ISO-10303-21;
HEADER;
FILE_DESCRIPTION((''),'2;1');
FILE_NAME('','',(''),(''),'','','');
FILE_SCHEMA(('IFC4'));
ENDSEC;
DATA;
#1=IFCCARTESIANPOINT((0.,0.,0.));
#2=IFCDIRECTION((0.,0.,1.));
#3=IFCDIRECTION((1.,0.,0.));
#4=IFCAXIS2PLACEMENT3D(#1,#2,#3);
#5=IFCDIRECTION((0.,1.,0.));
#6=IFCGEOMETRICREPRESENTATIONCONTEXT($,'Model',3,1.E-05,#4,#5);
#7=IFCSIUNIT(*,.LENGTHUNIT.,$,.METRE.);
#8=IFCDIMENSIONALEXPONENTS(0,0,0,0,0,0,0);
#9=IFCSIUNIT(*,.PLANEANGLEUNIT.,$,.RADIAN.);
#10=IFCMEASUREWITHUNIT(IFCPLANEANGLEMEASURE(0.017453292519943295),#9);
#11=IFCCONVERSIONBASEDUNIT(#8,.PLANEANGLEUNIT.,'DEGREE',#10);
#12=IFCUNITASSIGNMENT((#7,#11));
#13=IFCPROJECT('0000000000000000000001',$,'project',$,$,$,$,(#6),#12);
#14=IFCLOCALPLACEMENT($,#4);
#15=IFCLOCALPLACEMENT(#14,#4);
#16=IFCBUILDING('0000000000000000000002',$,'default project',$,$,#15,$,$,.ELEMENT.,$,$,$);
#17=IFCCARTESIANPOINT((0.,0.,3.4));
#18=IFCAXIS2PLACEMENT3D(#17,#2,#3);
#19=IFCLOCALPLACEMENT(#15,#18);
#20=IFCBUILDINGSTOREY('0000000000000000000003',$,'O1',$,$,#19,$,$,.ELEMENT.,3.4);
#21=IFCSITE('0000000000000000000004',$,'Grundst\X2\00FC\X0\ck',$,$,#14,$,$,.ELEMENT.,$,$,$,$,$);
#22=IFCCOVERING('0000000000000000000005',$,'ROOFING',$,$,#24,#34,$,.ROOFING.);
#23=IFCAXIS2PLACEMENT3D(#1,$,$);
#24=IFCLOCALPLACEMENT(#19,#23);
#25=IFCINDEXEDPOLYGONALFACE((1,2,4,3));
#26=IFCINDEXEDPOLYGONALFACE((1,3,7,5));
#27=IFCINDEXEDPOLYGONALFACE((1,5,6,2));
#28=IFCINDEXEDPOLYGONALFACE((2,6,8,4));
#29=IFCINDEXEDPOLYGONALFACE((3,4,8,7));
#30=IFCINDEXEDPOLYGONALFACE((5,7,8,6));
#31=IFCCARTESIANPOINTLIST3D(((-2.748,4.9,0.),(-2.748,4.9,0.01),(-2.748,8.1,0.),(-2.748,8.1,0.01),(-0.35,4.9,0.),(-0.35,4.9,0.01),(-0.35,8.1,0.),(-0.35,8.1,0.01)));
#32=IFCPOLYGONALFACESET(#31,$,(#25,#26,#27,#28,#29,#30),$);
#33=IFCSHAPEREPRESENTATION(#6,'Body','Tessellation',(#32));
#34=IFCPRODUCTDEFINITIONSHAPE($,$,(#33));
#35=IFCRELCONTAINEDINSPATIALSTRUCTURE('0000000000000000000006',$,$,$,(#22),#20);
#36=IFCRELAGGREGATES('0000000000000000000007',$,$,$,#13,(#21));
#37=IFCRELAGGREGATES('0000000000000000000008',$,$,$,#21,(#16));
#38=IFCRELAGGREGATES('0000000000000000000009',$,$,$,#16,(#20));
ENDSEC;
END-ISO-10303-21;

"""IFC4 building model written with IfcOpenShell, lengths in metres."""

from ifc_helpers import new_model, entity, si_unit, converted_unit, direction, frame, origin_with_axes, place, context, project, spatial, polyline, outline, extrude, element, save


model = new_model("IFC4")

# Units and contexts
model_context = context("Model", 3, precision=1e-05, world=origin_with_axes(), true_north=direction((0.0, 1.0, 0.0)))
ifc_project = project(units=[si_unit("LENGTHUNIT", "METRE"), converted_unit("PLANEANGLEUNIT", "DEGREE", entity("IfcPlaneAngleMeasure", 0.017453292519943295), si_unit("PLANEANGLEUNIT", "RADIAN"), dimensions=[0, 0, 0, 0, 0, 0, 0])], contexts=[model_context])

# Site, building, storey
site_placement = place(None, origin_with_axes())
site = spatial("IfcSite", under=ifc_project, at=site_placement, Name="Grundstück", CompositionType="ELEMENT")
building_placement = place(site_placement, origin_with_axes())
building = spatial("IfcBuilding", under=site, at=building_placement, Name="default project", CompositionType="ELEMENT")
placement_1 = place(building_placement, frame((0.0, 0.0, 3.4), z_axis=(0.0, 0.0, 1.0), x_axis=(1.0, 0.0, 0.0)))
storey = spatial("IfcBuildingStorey", under=building, at=placement_1, Name="O1", CompositionType="ELEMENT", Elevation=3.4)

# Shared definitions
slab_1_placement = place(placement_1, frame((0.0, 0.0, -0.4), z_axis=(0.0, 0.0, 1.0), x_axis=(1.0, 0.0, 0.0)))

# Covering
covering_1_placement = place(slab_1_placement, frame((0.0, 0.0, 0.2), z_axis=(0.0, 0.0, 1.0), x_axis=(1.0, 0.0, 0.0)))
element("IfcCovering", 1, at=covering_1_placement, inside=storey, Name="ROOFING", PredefinedType="ROOFING", context=model_context, shape_type="SweptSolid", body=[
    extrude(outline(polyline([(-0.35, 8.1), (-2.748, 8.1), (-2.748, 4.9), (-0.35, 4.9), (-0.35, 8.1)])), frame((0.0, 0.0, 0.2), z_axis=(0.0, 0.0, 1.0), x_axis=(1.0, 0.0, 0.0)), (0.0, 0.0, 1.0), 0.01),
])

save(model, "model.ifc")
